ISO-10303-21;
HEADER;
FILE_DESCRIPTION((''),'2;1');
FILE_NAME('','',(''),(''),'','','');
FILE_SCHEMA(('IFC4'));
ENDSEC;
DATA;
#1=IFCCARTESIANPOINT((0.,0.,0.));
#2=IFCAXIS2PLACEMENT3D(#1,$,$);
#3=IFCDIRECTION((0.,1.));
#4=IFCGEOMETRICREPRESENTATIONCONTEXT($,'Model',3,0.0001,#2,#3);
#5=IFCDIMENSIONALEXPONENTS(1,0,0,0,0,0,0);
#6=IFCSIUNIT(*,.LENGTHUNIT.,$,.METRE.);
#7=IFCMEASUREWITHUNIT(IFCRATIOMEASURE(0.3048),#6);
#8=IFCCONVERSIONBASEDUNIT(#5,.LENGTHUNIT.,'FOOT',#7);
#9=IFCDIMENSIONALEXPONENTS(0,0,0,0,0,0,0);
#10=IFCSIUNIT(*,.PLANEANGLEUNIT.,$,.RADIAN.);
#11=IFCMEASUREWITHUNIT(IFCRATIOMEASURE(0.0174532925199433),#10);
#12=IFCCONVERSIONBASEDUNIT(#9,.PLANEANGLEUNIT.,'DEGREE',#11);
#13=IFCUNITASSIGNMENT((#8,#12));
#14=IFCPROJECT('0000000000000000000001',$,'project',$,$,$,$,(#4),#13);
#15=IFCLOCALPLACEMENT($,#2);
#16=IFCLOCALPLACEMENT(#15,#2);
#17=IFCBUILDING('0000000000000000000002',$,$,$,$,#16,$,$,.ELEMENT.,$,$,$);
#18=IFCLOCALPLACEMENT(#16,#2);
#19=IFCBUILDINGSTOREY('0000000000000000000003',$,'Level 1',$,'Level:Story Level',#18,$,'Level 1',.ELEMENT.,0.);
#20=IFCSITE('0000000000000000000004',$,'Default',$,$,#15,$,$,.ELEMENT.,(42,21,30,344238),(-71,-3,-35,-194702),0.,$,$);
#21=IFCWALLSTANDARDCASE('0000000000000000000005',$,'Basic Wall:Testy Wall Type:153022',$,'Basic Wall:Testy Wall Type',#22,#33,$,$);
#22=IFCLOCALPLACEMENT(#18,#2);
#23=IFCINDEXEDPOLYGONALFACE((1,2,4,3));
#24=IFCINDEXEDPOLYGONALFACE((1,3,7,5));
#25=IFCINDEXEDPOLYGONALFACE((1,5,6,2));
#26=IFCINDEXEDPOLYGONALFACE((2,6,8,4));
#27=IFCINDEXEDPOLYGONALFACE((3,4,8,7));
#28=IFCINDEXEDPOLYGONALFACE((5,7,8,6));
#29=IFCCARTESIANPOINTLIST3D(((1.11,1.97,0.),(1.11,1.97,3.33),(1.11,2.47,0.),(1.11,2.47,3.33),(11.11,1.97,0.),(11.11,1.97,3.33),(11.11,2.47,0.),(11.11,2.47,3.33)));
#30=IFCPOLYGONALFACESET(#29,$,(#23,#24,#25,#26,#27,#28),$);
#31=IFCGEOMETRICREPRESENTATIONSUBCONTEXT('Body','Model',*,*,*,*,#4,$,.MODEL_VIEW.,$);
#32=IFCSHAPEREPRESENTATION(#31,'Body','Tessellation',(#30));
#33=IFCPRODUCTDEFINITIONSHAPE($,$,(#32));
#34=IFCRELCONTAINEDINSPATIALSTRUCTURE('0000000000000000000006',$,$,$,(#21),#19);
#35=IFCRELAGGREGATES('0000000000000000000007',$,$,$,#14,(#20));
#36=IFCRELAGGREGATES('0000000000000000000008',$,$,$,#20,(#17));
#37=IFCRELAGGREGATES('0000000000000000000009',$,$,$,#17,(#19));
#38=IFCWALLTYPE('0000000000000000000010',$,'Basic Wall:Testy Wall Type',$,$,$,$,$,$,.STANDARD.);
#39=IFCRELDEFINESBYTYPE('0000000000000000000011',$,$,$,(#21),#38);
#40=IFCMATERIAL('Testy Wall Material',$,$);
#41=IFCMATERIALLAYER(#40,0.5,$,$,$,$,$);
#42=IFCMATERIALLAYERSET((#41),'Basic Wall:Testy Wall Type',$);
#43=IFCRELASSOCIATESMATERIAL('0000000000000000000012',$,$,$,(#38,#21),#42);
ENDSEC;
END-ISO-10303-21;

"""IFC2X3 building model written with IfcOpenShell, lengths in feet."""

from ifc_helpers import new_model, entity, si_unit, converted_unit, direction, frame, frame_2d, origin, place, context, subcontext, project, spatial, rectangle, extrude, material, layer, layer_set, layer_usage, type_object, element, save


model = new_model("IFC2X3")

# Units and contexts
model_context = context("Model", 3, precision=0.0001, world=origin(), true_north=direction((0.0, 1.0)))
body_context = subcontext(model_context, "Body", "Model", "MODEL_VIEW")
ifc_project = project(units=[converted_unit("LENGTHUNIT", "FOOT", entity("IfcRatioMeasure", 0.3048), si_unit("LENGTHUNIT", "METRE"), dimensions=[1, 0, 0, 0, 0, 0, 0]), converted_unit("PLANEANGLEUNIT", "DEGREE", entity("IfcRatioMeasure", 0.0174532925199433), si_unit("PLANEANGLEUNIT", "RADIAN"), dimensions=[0, 0, 0, 0, 0, 0, 0])], contexts=[model_context])

# Site, building, storey
site_placement = place(None, origin())
site = spatial("IfcSite", under=ifc_project, at=site_placement, Name="Default", CompositionType="ELEMENT", RefLatitude=(42, 21, 30, 344238), RefLongitude=(-71, -3, -35, -194702), RefElevation=0.0)
building_placement = place(site_placement, origin())
building = spatial("IfcBuilding", under=site, at=building_placement, CompositionType="ELEMENT")
storey_placement = place(building_placement, origin())
storey = spatial("IfcBuildingStorey", under=building, at=storey_placement, Name="Level 1", ObjectType="Level:Story Level", LongName="Level 1", CompositionType="ELEMENT", Elevation=0.0)

# Wall
ifc_material = material(Name="Testy Wall Material")
ifc_layer = layer(ifc_material, 0.5)
ifc_layer_set = layer_set([ifc_layer], Name="Basic Wall:Testy Wall Type")
ifc_layer_usage = layer_usage(ifc_layer_set, "AXIS2", "NEGATIVE", 0.25)
wall_type = type_object("IfcWallType", Name="Basic Wall:Testy Wall Type", PredefinedType="STANDARD", material=ifc_layer_set)
wall_placement = place(storey_placement, frame((1.11, 2.22, 0.0)))
element("IfcWallStandardCase", 1, at=wall_placement, inside=storey, type_object=wall_type, material=ifc_layer_usage, Name="Basic Wall:Testy Wall Type:153022", ObjectType="Basic Wall:Testy Wall Type", context=body_context, shape_type="SweptSolid", body=[
    extrude(rectangle(XDim=10.0, YDim=0.5, at=frame_2d((5.0, 0.0), x_axis=(-1.0, 0.0))), origin(), (0.0, 0.0, 1.0), 3.33),
])

save(model, "model.ifc")
